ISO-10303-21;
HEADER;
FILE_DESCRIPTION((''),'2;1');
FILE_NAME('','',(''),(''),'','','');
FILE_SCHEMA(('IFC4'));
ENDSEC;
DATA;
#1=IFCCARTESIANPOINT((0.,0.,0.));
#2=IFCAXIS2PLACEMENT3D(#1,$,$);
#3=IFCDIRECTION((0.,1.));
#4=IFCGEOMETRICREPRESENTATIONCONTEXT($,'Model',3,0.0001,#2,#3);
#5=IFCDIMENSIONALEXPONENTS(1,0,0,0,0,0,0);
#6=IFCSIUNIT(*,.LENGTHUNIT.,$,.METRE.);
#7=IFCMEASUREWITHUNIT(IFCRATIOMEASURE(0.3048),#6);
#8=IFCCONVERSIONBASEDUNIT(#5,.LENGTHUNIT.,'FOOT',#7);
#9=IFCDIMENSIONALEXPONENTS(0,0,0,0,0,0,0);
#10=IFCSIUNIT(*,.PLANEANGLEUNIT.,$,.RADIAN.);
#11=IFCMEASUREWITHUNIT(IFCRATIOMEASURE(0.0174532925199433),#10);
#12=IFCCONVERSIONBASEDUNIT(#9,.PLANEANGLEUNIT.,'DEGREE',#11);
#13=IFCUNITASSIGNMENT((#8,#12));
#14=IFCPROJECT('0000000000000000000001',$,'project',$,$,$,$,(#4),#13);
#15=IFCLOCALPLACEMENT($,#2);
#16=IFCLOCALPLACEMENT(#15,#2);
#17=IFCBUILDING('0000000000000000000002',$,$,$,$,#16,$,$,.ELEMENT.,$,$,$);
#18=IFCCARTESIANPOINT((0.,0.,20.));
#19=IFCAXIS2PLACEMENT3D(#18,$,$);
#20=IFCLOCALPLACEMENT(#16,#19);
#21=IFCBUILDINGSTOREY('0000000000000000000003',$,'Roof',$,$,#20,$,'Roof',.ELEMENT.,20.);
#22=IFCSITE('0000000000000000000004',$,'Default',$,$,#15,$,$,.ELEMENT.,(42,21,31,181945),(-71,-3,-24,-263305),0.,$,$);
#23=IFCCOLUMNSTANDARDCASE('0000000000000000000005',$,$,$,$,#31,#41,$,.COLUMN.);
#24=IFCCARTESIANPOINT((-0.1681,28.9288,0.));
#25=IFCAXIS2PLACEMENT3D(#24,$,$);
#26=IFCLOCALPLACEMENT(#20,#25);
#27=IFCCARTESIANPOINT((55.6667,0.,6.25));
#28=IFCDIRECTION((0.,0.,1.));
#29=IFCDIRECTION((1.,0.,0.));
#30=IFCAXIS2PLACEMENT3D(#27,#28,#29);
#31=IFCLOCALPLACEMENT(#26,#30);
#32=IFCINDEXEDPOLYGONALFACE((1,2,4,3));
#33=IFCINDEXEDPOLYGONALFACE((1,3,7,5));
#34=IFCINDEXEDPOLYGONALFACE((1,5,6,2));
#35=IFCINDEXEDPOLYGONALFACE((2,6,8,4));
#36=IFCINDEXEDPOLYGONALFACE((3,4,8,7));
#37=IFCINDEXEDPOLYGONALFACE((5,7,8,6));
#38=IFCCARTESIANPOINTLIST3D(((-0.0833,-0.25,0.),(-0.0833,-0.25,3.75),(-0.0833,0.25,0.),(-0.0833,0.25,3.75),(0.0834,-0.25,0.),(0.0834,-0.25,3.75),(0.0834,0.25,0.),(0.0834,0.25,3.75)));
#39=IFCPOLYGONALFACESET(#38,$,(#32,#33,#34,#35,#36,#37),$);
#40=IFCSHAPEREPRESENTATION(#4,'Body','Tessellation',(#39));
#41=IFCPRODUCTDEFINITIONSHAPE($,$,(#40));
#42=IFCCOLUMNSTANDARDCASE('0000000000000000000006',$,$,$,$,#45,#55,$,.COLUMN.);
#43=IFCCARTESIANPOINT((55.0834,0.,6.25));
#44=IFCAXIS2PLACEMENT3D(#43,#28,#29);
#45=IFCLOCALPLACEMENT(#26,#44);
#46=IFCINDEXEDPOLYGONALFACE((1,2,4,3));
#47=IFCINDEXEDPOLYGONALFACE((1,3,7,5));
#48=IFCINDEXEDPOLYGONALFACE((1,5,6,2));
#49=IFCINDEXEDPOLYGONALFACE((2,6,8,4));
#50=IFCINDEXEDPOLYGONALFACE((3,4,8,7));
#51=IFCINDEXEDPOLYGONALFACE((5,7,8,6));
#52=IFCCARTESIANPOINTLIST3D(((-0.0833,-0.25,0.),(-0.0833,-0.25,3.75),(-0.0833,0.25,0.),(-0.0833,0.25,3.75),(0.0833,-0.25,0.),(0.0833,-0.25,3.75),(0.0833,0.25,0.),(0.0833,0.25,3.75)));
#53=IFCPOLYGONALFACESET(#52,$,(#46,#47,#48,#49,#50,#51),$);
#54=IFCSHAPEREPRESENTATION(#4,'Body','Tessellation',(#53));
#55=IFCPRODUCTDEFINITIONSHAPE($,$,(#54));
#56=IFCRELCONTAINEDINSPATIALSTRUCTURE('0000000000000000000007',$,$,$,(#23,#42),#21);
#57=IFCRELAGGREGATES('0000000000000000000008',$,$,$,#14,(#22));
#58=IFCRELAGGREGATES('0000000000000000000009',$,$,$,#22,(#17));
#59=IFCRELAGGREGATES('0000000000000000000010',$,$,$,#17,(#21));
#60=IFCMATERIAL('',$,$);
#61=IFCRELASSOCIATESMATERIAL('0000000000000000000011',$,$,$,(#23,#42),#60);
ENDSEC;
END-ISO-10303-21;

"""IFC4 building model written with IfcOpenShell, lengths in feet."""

from ifc_helpers import new_model, entity, si_unit, converted_unit, direction, frame, origin, place, context, project, spatial, rectangle, extrude, material, element, save


model = new_model("IFC4")

# Units and contexts
model_context = context("Model", 3, precision=0.0001, world=origin(), true_north=direction((0.0, 1.0)))
ifc_project = project(units=[converted_unit("LENGTHUNIT", "FOOT", entity("IfcRatioMeasure", 0.3048), si_unit("LENGTHUNIT", "METRE"), dimensions=[1, 0, 0, 0, 0, 0, 0]), converted_unit("PLANEANGLEUNIT", "DEGREE", entity("IfcRatioMeasure", 0.0174532925199433), si_unit("PLANEANGLEUNIT", "RADIAN"), dimensions=[0, 0, 0, 0, 0, 0, 0])], contexts=[model_context])

# Site, building, storey
site_placement = place(None, origin())
site = spatial("IfcSite", under=ifc_project, at=site_placement, Name="Default", CompositionType="ELEMENT", RefLatitude=(42, 21, 31, 181945), RefLongitude=(-71, -3, -24, -263305), RefElevation=0.0)
building_placement = place(site_placement, origin())
building = spatial("IfcBuilding", under=site, at=building_placement, CompositionType="ELEMENT")
storey_placement = place(building_placement, frame((0.0, 0.0, 20.0)))
storey = spatial("IfcBuildingStorey", under=building, at=storey_placement, Name="Roof", LongName="Roof", CompositionType="ELEMENT", Elevation=20.0)

# Columns
ifc_material_1 = material(Name="")
placement = place(storey_placement, frame((-0.1681, 28.9288, 0.0)))
for number, where, z_axis, x_axis in (
    (1, (55.6667, 0.0, 6.25), (0.0, 0.0, 1.0), (1.0, 0.0, 0.0)),
    (2, (55.0834, 0.0, 6.25), (0.0, 0.0, 1.0), (1.0, 0.0, 0.0)),
):
    element("IfcColumnStandardCase", number, at=place(placement, frame(where, z_axis=z_axis, x_axis=x_axis)), inside=storey, material=ifc_material_1, PredefinedType="COLUMN", context=model_context, shape_type="SweptSolid", body=[
        extrude(rectangle(XDim=0.1667, YDim=0.5), origin(), (0.0, 0.0, 1.0), 3.75),
    ])

save(model, "model.ifc")
